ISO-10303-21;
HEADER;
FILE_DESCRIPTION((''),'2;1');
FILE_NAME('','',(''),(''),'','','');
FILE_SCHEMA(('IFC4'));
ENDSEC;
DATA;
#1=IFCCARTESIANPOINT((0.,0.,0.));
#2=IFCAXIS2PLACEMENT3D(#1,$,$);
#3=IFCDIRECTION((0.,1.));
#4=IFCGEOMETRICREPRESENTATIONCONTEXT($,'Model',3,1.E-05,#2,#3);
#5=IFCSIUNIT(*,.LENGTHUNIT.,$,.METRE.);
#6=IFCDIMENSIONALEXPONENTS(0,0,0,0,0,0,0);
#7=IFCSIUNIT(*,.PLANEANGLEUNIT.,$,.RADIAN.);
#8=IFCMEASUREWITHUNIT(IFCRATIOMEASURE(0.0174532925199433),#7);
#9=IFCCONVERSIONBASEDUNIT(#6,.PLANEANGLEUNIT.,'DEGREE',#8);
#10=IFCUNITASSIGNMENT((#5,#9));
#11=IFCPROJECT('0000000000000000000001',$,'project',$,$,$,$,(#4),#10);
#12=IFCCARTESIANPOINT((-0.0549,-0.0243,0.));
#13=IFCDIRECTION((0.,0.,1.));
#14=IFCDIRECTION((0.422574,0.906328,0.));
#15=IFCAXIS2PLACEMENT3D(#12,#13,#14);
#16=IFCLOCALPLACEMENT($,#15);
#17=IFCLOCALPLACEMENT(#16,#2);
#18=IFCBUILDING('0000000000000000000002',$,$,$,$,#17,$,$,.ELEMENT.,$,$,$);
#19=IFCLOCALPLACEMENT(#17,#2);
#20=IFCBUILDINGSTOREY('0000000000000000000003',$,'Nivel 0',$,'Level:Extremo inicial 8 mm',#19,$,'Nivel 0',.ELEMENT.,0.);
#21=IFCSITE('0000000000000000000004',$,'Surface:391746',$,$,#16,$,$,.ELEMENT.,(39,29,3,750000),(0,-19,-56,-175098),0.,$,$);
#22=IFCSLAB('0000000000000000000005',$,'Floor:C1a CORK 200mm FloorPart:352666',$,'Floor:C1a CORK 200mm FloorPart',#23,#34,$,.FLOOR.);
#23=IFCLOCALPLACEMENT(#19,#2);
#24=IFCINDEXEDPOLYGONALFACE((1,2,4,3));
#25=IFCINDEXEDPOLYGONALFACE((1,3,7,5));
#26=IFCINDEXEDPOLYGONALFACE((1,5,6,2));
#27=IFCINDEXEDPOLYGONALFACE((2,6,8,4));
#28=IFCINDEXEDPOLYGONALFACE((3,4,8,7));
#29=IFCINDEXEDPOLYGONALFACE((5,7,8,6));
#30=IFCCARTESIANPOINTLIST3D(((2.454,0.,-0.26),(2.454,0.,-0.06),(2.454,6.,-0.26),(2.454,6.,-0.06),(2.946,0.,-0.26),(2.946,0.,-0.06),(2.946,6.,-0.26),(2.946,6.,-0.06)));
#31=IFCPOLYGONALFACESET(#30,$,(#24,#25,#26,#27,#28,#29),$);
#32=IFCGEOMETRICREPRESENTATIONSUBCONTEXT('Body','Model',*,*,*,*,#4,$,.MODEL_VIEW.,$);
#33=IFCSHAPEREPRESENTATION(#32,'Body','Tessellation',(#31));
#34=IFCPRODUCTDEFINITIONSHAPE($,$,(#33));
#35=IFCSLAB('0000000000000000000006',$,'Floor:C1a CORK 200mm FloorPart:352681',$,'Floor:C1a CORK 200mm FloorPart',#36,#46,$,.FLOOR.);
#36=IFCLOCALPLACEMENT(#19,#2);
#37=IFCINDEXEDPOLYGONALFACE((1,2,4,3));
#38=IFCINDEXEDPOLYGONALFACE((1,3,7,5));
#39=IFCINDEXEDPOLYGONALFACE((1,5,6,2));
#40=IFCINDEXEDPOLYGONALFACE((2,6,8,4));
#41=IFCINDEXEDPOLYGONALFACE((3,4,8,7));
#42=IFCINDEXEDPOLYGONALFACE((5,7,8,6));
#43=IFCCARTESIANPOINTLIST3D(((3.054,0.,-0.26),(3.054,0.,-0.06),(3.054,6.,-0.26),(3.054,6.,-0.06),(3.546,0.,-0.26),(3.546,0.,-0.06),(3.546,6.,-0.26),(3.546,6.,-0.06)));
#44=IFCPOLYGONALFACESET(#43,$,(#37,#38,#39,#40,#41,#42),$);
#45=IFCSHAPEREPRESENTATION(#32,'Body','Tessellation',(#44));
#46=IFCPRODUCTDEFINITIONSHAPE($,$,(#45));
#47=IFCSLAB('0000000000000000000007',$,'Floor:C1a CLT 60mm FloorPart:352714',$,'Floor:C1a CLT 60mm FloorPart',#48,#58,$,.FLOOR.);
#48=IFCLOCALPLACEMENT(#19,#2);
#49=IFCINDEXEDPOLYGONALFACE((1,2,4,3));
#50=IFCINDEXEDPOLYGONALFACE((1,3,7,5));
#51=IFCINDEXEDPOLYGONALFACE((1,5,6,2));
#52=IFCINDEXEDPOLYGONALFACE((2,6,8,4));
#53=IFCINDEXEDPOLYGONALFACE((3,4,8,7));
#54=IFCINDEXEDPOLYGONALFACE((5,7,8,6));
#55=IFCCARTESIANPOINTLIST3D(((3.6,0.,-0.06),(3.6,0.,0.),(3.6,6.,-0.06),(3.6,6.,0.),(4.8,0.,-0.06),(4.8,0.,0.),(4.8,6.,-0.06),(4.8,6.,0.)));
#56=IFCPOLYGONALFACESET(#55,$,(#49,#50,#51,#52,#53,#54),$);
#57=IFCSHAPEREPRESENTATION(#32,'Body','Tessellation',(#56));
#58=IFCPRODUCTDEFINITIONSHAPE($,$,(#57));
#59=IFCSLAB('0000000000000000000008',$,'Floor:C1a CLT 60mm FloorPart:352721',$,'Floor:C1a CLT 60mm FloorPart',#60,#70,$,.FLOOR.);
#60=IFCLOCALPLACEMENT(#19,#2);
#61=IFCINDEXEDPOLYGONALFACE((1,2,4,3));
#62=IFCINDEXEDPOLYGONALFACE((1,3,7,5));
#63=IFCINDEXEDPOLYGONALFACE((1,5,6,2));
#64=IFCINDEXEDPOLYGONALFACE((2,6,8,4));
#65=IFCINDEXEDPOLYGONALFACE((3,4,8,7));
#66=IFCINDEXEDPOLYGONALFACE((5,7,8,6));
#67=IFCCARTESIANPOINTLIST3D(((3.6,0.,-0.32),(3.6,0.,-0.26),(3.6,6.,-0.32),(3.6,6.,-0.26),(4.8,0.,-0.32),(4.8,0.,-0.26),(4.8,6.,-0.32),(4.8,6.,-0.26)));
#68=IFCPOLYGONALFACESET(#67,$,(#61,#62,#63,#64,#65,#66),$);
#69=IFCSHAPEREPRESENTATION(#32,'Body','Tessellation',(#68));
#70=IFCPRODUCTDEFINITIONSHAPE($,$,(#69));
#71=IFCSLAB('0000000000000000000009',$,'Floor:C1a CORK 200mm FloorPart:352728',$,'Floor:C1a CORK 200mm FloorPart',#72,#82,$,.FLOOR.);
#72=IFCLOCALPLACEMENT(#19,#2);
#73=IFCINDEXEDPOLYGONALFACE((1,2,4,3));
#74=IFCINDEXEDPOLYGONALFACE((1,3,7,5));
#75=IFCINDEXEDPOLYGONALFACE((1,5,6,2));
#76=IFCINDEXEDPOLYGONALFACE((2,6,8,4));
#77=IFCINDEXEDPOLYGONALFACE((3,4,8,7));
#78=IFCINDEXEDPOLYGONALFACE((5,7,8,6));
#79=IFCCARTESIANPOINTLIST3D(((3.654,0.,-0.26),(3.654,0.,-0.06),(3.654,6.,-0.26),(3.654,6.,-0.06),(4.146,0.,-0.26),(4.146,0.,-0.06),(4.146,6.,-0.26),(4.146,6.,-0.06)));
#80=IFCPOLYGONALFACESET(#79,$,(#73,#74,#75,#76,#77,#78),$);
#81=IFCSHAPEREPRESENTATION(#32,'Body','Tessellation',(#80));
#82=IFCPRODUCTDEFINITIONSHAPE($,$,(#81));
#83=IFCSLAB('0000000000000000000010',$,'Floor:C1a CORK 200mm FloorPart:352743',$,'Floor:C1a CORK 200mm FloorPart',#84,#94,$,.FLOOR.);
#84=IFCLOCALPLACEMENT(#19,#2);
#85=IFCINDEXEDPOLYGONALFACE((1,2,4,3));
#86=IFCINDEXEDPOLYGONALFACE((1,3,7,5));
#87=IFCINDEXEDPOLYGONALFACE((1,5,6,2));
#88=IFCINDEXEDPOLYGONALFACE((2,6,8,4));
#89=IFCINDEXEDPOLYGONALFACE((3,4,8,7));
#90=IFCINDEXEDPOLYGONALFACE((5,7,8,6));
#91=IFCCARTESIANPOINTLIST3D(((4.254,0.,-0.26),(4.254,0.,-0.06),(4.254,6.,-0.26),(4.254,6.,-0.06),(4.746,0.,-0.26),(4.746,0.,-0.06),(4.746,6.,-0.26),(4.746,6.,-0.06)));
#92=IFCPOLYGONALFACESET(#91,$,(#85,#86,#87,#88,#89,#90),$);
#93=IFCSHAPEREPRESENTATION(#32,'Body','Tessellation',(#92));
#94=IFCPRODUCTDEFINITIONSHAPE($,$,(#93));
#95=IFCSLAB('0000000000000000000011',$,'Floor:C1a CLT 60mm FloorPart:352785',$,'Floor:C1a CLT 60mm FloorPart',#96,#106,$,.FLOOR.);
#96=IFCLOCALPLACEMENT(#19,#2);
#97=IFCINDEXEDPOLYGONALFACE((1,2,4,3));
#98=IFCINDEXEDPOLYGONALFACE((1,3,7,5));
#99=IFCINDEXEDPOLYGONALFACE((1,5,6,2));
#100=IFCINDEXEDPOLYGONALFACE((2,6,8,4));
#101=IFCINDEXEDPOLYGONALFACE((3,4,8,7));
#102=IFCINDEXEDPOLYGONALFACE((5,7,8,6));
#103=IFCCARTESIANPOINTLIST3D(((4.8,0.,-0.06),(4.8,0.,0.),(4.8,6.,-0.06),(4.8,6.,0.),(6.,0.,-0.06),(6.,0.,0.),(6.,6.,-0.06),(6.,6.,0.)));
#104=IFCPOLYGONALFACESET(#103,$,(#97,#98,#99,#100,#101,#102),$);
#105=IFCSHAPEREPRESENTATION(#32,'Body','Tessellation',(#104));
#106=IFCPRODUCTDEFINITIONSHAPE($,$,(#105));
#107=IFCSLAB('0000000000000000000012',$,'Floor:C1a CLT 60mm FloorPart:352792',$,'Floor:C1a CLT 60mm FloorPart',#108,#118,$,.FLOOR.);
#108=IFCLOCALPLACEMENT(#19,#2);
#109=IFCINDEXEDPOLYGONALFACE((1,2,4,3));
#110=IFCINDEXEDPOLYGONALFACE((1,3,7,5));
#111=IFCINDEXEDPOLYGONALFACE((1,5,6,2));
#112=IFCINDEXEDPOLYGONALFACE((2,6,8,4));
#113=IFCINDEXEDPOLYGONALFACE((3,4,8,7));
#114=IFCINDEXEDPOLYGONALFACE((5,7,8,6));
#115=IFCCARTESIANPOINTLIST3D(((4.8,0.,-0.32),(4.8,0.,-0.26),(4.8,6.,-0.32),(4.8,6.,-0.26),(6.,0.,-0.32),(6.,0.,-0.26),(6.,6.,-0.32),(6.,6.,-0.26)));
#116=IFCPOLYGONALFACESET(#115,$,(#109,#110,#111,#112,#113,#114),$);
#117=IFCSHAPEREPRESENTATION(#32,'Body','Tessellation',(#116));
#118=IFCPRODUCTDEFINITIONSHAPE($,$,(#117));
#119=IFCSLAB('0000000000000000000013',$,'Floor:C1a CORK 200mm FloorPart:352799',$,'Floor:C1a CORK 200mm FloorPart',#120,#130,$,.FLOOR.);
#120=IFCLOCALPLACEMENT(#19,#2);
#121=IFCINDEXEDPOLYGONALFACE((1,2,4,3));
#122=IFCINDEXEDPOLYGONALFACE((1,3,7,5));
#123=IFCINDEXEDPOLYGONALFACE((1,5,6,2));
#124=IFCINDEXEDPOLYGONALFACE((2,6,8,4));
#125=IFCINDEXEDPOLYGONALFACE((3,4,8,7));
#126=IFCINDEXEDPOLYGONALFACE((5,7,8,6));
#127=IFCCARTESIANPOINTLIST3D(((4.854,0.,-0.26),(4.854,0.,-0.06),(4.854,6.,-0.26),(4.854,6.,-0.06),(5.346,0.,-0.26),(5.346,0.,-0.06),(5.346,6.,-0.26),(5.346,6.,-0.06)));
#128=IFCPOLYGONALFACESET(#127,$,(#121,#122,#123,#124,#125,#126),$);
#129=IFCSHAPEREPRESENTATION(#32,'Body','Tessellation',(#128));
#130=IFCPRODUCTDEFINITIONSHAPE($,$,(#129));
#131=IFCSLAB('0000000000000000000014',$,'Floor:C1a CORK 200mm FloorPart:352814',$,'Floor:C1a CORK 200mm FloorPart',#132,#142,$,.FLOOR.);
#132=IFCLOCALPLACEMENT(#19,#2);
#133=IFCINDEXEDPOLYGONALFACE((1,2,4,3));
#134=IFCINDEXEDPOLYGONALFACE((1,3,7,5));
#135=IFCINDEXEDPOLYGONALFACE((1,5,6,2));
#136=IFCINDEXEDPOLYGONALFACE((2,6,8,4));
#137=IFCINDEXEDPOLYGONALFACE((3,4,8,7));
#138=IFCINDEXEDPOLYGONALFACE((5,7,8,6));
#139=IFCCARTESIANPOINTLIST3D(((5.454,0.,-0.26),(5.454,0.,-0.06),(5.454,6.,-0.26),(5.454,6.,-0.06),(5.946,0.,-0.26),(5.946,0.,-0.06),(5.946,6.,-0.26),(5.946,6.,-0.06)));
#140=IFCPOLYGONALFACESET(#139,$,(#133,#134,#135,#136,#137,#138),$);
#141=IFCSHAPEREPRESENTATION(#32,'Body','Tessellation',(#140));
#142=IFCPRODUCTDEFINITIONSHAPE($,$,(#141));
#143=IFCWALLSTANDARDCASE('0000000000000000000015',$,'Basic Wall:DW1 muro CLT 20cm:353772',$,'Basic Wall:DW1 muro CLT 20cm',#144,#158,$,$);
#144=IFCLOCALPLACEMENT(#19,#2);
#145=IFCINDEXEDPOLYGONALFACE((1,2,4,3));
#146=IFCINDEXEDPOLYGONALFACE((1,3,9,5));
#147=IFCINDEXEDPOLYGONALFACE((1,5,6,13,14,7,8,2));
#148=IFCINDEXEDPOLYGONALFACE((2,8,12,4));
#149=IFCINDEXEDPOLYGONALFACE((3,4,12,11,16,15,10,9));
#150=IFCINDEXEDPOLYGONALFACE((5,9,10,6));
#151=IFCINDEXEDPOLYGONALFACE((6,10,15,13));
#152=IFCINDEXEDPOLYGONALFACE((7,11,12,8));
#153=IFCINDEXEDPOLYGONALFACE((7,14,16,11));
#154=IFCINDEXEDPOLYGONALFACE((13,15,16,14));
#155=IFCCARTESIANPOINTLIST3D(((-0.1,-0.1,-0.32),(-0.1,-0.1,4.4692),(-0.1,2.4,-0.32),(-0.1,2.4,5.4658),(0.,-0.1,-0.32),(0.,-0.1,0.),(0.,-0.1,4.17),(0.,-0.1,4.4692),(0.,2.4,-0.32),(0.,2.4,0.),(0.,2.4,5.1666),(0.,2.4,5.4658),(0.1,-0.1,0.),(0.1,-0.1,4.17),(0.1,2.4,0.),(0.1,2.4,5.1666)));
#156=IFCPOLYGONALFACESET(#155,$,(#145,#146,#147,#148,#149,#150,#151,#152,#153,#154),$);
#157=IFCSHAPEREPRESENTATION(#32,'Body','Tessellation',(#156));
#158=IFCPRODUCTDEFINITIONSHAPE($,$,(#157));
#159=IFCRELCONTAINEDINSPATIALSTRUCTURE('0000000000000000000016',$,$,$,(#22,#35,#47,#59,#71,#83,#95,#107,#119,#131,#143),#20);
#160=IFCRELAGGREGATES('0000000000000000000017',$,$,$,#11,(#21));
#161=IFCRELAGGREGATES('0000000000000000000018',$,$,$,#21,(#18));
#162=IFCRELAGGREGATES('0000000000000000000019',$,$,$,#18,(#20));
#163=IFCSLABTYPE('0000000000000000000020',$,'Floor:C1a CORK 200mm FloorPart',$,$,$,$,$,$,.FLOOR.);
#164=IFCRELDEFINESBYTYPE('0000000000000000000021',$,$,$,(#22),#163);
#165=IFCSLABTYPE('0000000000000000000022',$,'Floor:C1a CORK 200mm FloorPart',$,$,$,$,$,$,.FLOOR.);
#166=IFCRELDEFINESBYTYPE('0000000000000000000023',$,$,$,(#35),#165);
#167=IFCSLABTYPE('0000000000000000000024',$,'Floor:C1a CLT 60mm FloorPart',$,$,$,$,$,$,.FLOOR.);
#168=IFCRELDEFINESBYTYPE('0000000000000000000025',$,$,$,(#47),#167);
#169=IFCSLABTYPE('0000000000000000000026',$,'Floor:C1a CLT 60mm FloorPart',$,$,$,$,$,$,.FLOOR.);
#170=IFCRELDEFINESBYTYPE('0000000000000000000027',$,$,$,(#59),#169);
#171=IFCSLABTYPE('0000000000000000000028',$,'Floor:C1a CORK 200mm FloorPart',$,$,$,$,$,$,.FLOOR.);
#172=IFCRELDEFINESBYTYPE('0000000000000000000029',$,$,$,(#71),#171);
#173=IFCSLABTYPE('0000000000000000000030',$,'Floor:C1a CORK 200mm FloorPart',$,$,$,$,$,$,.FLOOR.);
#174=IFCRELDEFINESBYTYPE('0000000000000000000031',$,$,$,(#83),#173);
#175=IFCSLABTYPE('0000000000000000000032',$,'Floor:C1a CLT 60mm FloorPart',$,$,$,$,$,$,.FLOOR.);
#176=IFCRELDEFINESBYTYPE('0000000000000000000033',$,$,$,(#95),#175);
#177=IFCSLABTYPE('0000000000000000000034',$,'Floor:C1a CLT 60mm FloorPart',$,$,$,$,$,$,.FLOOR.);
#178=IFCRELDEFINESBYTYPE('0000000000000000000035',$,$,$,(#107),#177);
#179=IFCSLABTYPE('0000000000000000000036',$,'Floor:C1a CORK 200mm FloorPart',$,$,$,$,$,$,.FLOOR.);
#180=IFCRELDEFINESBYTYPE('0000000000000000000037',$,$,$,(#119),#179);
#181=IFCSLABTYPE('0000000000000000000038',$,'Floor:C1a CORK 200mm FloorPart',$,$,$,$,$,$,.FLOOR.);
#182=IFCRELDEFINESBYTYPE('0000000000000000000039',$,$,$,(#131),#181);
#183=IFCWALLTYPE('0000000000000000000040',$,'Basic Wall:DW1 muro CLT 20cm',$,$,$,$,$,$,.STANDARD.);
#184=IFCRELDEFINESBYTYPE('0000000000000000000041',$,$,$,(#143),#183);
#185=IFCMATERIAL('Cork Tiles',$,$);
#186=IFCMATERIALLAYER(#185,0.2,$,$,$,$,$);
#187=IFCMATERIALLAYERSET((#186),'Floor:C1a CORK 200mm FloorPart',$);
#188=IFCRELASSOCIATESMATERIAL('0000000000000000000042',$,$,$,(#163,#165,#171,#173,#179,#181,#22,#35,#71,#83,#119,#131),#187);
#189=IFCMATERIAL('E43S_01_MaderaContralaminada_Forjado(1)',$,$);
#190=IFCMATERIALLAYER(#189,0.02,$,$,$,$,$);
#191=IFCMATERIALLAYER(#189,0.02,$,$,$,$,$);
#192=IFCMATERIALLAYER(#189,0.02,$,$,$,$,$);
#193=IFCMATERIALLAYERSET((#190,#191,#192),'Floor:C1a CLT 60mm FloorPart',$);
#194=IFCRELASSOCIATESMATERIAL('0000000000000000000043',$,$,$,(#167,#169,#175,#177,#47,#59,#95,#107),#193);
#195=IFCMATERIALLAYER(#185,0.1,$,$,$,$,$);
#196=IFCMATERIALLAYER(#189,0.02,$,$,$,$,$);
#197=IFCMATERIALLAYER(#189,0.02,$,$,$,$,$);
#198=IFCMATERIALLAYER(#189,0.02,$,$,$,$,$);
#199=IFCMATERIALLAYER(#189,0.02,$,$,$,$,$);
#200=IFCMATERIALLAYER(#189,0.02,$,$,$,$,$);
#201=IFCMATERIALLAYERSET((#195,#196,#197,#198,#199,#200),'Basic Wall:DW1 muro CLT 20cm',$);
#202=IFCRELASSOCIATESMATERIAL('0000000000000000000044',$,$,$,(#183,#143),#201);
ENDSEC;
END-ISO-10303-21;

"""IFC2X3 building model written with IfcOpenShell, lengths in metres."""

from ifc_helpers import new_model, entity, si_unit, converted_unit, direction, frame, frame_2d, origin, place, context, subcontext, project, spatial, polyline, rectangle, extrude, clip, bounded_halfspace, material, layer, layer_set, layer_usage, type_object, element, save


model = new_model("IFC2X3")

# Units and contexts
model_context = context("Model", 3, precision=1e-05, world=origin(), true_north=direction((0.0, 1.0)))
body_context = subcontext(model_context, "Body", "Model", "MODEL_VIEW")
ifc_project = project(units=[si_unit("LENGTHUNIT", "METRE"), converted_unit("PLANEANGLEUNIT", "DEGREE", entity("IfcRatioMeasure", 0.0174532925199433), si_unit("PLANEANGLEUNIT", "RADIAN"), dimensions=[0, 0, 0, 0, 0, 0, 0])], contexts=[model_context])

# Site, building, storey
site_placement = place(None, frame((-0.0549, -0.0243, 0.0), z_axis=(0.0, 0.0, 1.0), x_axis=(0.422574, 0.906328, 0.0)))
site = spatial("IfcSite", under=ifc_project, at=site_placement, Name="Surface:391746", CompositionType="ELEMENT", RefLatitude=(39, 29, 3, 750000), RefLongitude=(0, -19, -56, -175098), RefElevation=0.0)
building_placement = place(site_placement, origin())
building = spatial("IfcBuilding", under=site, at=building_placement, CompositionType="ELEMENT")
storey_placement = place(building_placement, origin())
storey = spatial("IfcBuildingStorey", under=building, at=storey_placement, Name="Nivel 0", ObjectType="Level:Extremo inicial 8 mm", LongName="Nivel 0", CompositionType="ELEMENT", Elevation=0.0)

# Shared definitions
ifc_material_1 = material(Name="E43S_01_MaderaContralaminada_Forjado(1)")

# Slabs
ifc_layer_1 = layer(ifc_material_1, 0.02)
ifc_layer_2 = layer(ifc_material_1, 0.02)
ifc_layer_3 = layer(ifc_material_1, 0.02)
ifc_layer_set_1 = layer_set([ifc_layer_1, ifc_layer_2, ifc_layer_3], Name="Floor:C1a CLT 60mm FloorPart")
ifc_material_2 = material(Name="Cork Tiles")
ifc_layer_4 = layer(ifc_material_2, 0.2)
ifc_layer_set_2 = layer_set([ifc_layer_4], Name="Floor:C1a CORK 200mm FloorPart")
ifc_layer_usage_1 = layer_usage(ifc_layer_set_2, "AXIS3", "POSITIVE", 0.0)
slab_type_1 = type_object("IfcSlabType", Name="Floor:C1a CORK 200mm FloorPart", PredefinedType="FLOOR", material=ifc_layer_set_2)
slab_1_placement = place(storey_placement, origin())
element("IfcSlab", 1, at=slab_1_placement, inside=storey, type_object=slab_type_1, material=ifc_layer_usage_1, Name="Floor:C1a CORK 200mm FloorPart:352666", ObjectType="Floor:C1a CORK 200mm FloorPart", PredefinedType="FLOOR", context=body_context, shape_type="SweptSolid", body=[
    extrude(rectangle(XDim=6.0, YDim=0.492, at=frame_2d((0.0, 0.0), x_axis=(1.0, 0.0))), frame((2.7, 3.0, -0.06), z_axis=(0.0, 0.0, -1.0), x_axis=(0.0, 1.0, 0.0)), (0.0, 0.0, 1.0), 0.2),
])
ifc_layer_usage_2 = layer_usage(ifc_layer_set_2, "AXIS3", "POSITIVE", 0.0)
slab_type_2 = type_object("IfcSlabType", Name="Floor:C1a CORK 200mm FloorPart", PredefinedType="FLOOR", material=ifc_layer_set_2)
slab_2_placement = place(storey_placement, origin())
element("IfcSlab", 2, at=slab_2_placement, inside=storey, type_object=slab_type_2, material=ifc_layer_usage_2, Name="Floor:C1a CORK 200mm FloorPart:352681", ObjectType="Floor:C1a CORK 200mm FloorPart", PredefinedType="FLOOR", context=body_context, shape_type="SweptSolid", body=[
    extrude(rectangle(XDim=6.0, YDim=0.492, at=frame_2d((0.0, 0.0), x_axis=(1.0, 0.0))), frame((3.3, 3.0, -0.06), z_axis=(0.0, 0.0, -1.0), x_axis=(0.0, 1.0, 0.0)), (0.0, 0.0, 1.0), 0.2),
])
ifc_layer_usage_3 = layer_usage(ifc_layer_set_1, "AXIS3", "POSITIVE", 0.0)
slab_type_3 = type_object("IfcSlabType", Name="Floor:C1a CLT 60mm FloorPart", PredefinedType="FLOOR", material=ifc_layer_set_1)
slab_3_placement = place(storey_placement, origin())
element("IfcSlab", 3, at=slab_3_placement, inside=storey, type_object=slab_type_3, material=ifc_layer_usage_3, Name="Floor:C1a CLT 60mm FloorPart:352714", ObjectType="Floor:C1a CLT 60mm FloorPart", PredefinedType="FLOOR", context=body_context, shape_type="SweptSolid", body=[
    extrude(rectangle(XDim=6.0, YDim=1.2, at=frame_2d((0.0, 0.0), x_axis=(1.0, 0.0))), frame((4.2, 3.0, 0.0), z_axis=(0.0, 0.0, -1.0), x_axis=(0.0, 1.0, 0.0)), (0.0, 0.0, 1.0), 0.06),
])
ifc_layer_usage_4 = layer_usage(ifc_layer_set_1, "AXIS3", "POSITIVE", 0.0)
slab_type_4 = type_object("IfcSlabType", Name="Floor:C1a CLT 60mm FloorPart", PredefinedType="FLOOR", material=ifc_layer_set_1)
slab_4_placement = place(storey_placement, origin())
element("IfcSlab", 4, at=slab_4_placement, inside=storey, type_object=slab_type_4, material=ifc_layer_usage_4, Name="Floor:C1a CLT 60mm FloorPart:352721", ObjectType="Floor:C1a CLT 60mm FloorPart", PredefinedType="FLOOR", context=body_context, shape_type="SweptSolid", body=[
    extrude(rectangle(XDim=6.0, YDim=1.2, at=frame_2d((0.0, 0.0), x_axis=(1.0, 0.0))), frame((4.2, 3.0, -0.26), z_axis=(0.0, 0.0, -1.0), x_axis=(0.0, 1.0, 0.0)), (0.0, 0.0, 1.0), 0.06),
])
ifc_layer_usage_5 = layer_usage(ifc_layer_set_2, "AXIS3", "POSITIVE", 0.0)
slab_type_5 = type_object("IfcSlabType", Name="Floor:C1a CORK 200mm FloorPart", PredefinedType="FLOOR", material=ifc_layer_set_2)
slab_5_placement = place(storey_placement, origin())
element("IfcSlab", 5, at=slab_5_placement, inside=storey, type_object=slab_type_5, material=ifc_layer_usage_5, Name="Floor:C1a CORK 200mm FloorPart:352728", ObjectType="Floor:C1a CORK 200mm FloorPart", PredefinedType="FLOOR", context=body_context, shape_type="SweptSolid", body=[
    extrude(rectangle(XDim=6.0, YDim=0.492, at=frame_2d((0.0, 0.0), x_axis=(1.0, 0.0))), frame((3.9, 3.0, -0.06), z_axis=(0.0, 0.0, -1.0), x_axis=(0.0, 1.0, 0.0)), (0.0, 0.0, 1.0), 0.2),
])
ifc_layer_usage_6 = layer_usage(ifc_layer_set_2, "AXIS3", "POSITIVE", 0.0)
slab_type_6 = type_object("IfcSlabType", Name="Floor:C1a CORK 200mm FloorPart", PredefinedType="FLOOR", material=ifc_layer_set_2)
slab_6_placement = place(storey_placement, origin())
element("IfcSlab", 6, at=slab_6_placement, inside=storey, type_object=slab_type_6, material=ifc_layer_usage_6, Name="Floor:C1a CORK 200mm FloorPart:352743", ObjectType="Floor:C1a CORK 200mm FloorPart", PredefinedType="FLOOR", context=body_context, shape_type="SweptSolid", body=[
    extrude(rectangle(XDim=6.0, YDim=0.492, at=frame_2d((0.0, 0.0), x_axis=(1.0, 0.0))), frame((4.5, 3.0, -0.06), z_axis=(0.0, 0.0, -1.0), x_axis=(0.0, 1.0, 0.0)), (0.0, 0.0, 1.0), 0.2),
])
ifc_layer_usage_7 = layer_usage(ifc_layer_set_1, "AXIS3", "POSITIVE", 0.0)
slab_type_7 = type_object("IfcSlabType", Name="Floor:C1a CLT 60mm FloorPart", PredefinedType="FLOOR", material=ifc_layer_set_1)
slab_7_placement = place(storey_placement, origin())
element("IfcSlab", 7, at=slab_7_placement, inside=storey, type_object=slab_type_7, material=ifc_layer_usage_7, Name="Floor:C1a CLT 60mm FloorPart:352785", ObjectType="Floor:C1a CLT 60mm FloorPart", PredefinedType="FLOOR", context=body_context, shape_type="SweptSolid", body=[
    extrude(rectangle(XDim=6.0, YDim=1.2, at=frame_2d((0.0, 0.0), x_axis=(1.0, 0.0))), frame((5.4, 3.0, 0.0), z_axis=(0.0, 0.0, -1.0), x_axis=(0.0, 1.0, 0.0)), (0.0, 0.0, 1.0), 0.06),
])
ifc_layer_usage_8 = layer_usage(ifc_layer_set_1, "AXIS3", "POSITIVE", 0.0)
slab_type_8 = type_object("IfcSlabType", Name="Floor:C1a CLT 60mm FloorPart", PredefinedType="FLOOR", material=ifc_layer_set_1)
slab_8_placement = place(storey_placement, origin())
element("IfcSlab", 8, at=slab_8_placement, inside=storey, type_object=slab_type_8, material=ifc_layer_usage_8, Name="Floor:C1a CLT 60mm FloorPart:352792", ObjectType="Floor:C1a CLT 60mm FloorPart", PredefinedType="FLOOR", context=body_context, shape_type="SweptSolid", body=[
    extrude(rectangle(XDim=6.0, YDim=1.2, at=frame_2d((0.0, 0.0), x_axis=(1.0, 0.0))), frame((5.4, 3.0, -0.26), z_axis=(0.0, 0.0, -1.0), x_axis=(0.0, 1.0, 0.0)), (0.0, 0.0, 1.0), 0.06),
])
ifc_layer_usage_9 = layer_usage(ifc_layer_set_2, "AXIS3", "POSITIVE", 0.0)
slab_type_9 = type_object("IfcSlabType", Name="Floor:C1a CORK 200mm FloorPart", PredefinedType="FLOOR", material=ifc_layer_set_2)
slab_9_placement = place(storey_placement, origin())
element("IfcSlab", 9, at=slab_9_placement, inside=storey, type_object=slab_type_9, material=ifc_layer_usage_9, Name="Floor:C1a CORK 200mm FloorPart:352799", ObjectType="Floor:C1a CORK 200mm FloorPart", PredefinedType="FLOOR", context=body_context, shape_type="SweptSolid", body=[
    extrude(rectangle(XDim=6.0, YDim=0.492, at=frame_2d((0.0, 0.0), x_axis=(1.0, 0.0))), frame((5.1, 3.0, -0.06), z_axis=(0.0, 0.0, -1.0), x_axis=(0.0, 1.0, 0.0)), (0.0, 0.0, 1.0), 0.2),
])
ifc_layer_usage_10 = layer_usage(ifc_layer_set_2, "AXIS3", "POSITIVE", 0.0)
slab_type_10 = type_object("IfcSlabType", Name="Floor:C1a CORK 200mm FloorPart", PredefinedType="FLOOR", material=ifc_layer_set_2)
slab_10_placement = place(storey_placement, origin())
element("IfcSlab", 10, at=slab_10_placement, inside=storey, type_object=slab_type_10, material=ifc_layer_usage_10, Name="Floor:C1a CORK 200mm FloorPart:352814", ObjectType="Floor:C1a CORK 200mm FloorPart", PredefinedType="FLOOR", context=body_context, shape_type="SweptSolid", body=[
    extrude(rectangle(XDim=6.0, YDim=0.492, at=frame_2d((0.0, 0.0), x_axis=(1.0, 0.0))), frame((5.7, 3.0, -0.06), z_axis=(0.0, 0.0, -1.0), x_axis=(0.0, 1.0, 0.0)), (0.0, 0.0, 1.0), 0.2),
])

# Wall
ifc_layer_5 = layer(ifc_material_2, 0.1)
ifc_layer_6 = layer(ifc_material_1, 0.02)
ifc_layer_7 = layer(ifc_material_1, 0.02)
ifc_layer_8 = layer(ifc_material_1, 0.02)
ifc_layer_9 = layer(ifc_material_1, 0.02)
ifc_layer_10 = layer(ifc_material_1, 0.02)
ifc_layer_set_3 = layer_set([ifc_layer_5, ifc_layer_6, ifc_layer_7, ifc_layer_8, ifc_layer_9, ifc_layer_10], Name="Basic Wall:DW1 muro CLT 20cm")
ifc_layer_usage_11 = layer_usage(ifc_layer_set_3, "AXIS2", "NEGATIVE", 0.1)
wall_type_1 = type_object("IfcWallType", Name="Basic Wall:DW1 muro CLT 20cm", PredefinedType="STANDARD", material=ifc_layer_set_3)
wall_1_placement = place(storey_placement, frame((0.0, -0.1, -0.32), z_axis=(0.0, 0.0, 1.0), x_axis=(0.0, 1.0, 0.0)))
element("IfcWallStandardCase", 11, at=wall_1_placement, inside=storey, type_object=wall_type_1, material=ifc_layer_usage_11, Name="Basic Wall:DW1 muro CLT 20cm:353772", ObjectType="Basic Wall:DW1 muro CLT 20cm", context=body_context, shape_type="Clipping", body=[
    clip(clip(clip(extrude(rectangle(XDim=2.5, YDim=0.2, at=frame_2d((1.25, 0.0), x_axis=(-1.0, 0.0))), origin(), (0.0, 0.0, 1.0), 5.7858), bounded_halfspace(frame((0.0, -0.1, 4.49), z_axis=(-0.370288, 0.0, 0.928917), x_axis=(0.0, -1.0, 0.0)), False, frame((0.0, -0.1, 4.49)), polyline([(0.0, 0.0), (0.2, 0.0), (2.5, 0.0), (2.5, 0.1), (0.0, 0.1), (0.0, 0.0)]))), bounded_halfspace(frame((2.5, 0.0, 5.7858), z_axis=(-0.370288, 0.0, 0.928917), x_axis=(0.0, -1.0, 0.0)), False, frame((2.5, 0.0, 5.7858)), polyline([(0.0, 0.0), (0.0, 0.1), (-2.5, 0.1), (-2.5, 0.0), (0.0, 0.0)]))), bounded_halfspace(frame((2.5, -0.1, 0.32), z_axis=(0.0, 0.0, -1.0), x_axis=(0.0, 1.0, 0.0)), False, frame((2.5, -0.1, 0.32)), polyline([(0.0, 0.0), (0.0, 0.1), (-2.5, 0.1), (-2.5, 0.0), (-2.4, 0.0), (-2.3, 0.0), (0.0, 0.0)]))),
])

save(model, "model.ifc")
